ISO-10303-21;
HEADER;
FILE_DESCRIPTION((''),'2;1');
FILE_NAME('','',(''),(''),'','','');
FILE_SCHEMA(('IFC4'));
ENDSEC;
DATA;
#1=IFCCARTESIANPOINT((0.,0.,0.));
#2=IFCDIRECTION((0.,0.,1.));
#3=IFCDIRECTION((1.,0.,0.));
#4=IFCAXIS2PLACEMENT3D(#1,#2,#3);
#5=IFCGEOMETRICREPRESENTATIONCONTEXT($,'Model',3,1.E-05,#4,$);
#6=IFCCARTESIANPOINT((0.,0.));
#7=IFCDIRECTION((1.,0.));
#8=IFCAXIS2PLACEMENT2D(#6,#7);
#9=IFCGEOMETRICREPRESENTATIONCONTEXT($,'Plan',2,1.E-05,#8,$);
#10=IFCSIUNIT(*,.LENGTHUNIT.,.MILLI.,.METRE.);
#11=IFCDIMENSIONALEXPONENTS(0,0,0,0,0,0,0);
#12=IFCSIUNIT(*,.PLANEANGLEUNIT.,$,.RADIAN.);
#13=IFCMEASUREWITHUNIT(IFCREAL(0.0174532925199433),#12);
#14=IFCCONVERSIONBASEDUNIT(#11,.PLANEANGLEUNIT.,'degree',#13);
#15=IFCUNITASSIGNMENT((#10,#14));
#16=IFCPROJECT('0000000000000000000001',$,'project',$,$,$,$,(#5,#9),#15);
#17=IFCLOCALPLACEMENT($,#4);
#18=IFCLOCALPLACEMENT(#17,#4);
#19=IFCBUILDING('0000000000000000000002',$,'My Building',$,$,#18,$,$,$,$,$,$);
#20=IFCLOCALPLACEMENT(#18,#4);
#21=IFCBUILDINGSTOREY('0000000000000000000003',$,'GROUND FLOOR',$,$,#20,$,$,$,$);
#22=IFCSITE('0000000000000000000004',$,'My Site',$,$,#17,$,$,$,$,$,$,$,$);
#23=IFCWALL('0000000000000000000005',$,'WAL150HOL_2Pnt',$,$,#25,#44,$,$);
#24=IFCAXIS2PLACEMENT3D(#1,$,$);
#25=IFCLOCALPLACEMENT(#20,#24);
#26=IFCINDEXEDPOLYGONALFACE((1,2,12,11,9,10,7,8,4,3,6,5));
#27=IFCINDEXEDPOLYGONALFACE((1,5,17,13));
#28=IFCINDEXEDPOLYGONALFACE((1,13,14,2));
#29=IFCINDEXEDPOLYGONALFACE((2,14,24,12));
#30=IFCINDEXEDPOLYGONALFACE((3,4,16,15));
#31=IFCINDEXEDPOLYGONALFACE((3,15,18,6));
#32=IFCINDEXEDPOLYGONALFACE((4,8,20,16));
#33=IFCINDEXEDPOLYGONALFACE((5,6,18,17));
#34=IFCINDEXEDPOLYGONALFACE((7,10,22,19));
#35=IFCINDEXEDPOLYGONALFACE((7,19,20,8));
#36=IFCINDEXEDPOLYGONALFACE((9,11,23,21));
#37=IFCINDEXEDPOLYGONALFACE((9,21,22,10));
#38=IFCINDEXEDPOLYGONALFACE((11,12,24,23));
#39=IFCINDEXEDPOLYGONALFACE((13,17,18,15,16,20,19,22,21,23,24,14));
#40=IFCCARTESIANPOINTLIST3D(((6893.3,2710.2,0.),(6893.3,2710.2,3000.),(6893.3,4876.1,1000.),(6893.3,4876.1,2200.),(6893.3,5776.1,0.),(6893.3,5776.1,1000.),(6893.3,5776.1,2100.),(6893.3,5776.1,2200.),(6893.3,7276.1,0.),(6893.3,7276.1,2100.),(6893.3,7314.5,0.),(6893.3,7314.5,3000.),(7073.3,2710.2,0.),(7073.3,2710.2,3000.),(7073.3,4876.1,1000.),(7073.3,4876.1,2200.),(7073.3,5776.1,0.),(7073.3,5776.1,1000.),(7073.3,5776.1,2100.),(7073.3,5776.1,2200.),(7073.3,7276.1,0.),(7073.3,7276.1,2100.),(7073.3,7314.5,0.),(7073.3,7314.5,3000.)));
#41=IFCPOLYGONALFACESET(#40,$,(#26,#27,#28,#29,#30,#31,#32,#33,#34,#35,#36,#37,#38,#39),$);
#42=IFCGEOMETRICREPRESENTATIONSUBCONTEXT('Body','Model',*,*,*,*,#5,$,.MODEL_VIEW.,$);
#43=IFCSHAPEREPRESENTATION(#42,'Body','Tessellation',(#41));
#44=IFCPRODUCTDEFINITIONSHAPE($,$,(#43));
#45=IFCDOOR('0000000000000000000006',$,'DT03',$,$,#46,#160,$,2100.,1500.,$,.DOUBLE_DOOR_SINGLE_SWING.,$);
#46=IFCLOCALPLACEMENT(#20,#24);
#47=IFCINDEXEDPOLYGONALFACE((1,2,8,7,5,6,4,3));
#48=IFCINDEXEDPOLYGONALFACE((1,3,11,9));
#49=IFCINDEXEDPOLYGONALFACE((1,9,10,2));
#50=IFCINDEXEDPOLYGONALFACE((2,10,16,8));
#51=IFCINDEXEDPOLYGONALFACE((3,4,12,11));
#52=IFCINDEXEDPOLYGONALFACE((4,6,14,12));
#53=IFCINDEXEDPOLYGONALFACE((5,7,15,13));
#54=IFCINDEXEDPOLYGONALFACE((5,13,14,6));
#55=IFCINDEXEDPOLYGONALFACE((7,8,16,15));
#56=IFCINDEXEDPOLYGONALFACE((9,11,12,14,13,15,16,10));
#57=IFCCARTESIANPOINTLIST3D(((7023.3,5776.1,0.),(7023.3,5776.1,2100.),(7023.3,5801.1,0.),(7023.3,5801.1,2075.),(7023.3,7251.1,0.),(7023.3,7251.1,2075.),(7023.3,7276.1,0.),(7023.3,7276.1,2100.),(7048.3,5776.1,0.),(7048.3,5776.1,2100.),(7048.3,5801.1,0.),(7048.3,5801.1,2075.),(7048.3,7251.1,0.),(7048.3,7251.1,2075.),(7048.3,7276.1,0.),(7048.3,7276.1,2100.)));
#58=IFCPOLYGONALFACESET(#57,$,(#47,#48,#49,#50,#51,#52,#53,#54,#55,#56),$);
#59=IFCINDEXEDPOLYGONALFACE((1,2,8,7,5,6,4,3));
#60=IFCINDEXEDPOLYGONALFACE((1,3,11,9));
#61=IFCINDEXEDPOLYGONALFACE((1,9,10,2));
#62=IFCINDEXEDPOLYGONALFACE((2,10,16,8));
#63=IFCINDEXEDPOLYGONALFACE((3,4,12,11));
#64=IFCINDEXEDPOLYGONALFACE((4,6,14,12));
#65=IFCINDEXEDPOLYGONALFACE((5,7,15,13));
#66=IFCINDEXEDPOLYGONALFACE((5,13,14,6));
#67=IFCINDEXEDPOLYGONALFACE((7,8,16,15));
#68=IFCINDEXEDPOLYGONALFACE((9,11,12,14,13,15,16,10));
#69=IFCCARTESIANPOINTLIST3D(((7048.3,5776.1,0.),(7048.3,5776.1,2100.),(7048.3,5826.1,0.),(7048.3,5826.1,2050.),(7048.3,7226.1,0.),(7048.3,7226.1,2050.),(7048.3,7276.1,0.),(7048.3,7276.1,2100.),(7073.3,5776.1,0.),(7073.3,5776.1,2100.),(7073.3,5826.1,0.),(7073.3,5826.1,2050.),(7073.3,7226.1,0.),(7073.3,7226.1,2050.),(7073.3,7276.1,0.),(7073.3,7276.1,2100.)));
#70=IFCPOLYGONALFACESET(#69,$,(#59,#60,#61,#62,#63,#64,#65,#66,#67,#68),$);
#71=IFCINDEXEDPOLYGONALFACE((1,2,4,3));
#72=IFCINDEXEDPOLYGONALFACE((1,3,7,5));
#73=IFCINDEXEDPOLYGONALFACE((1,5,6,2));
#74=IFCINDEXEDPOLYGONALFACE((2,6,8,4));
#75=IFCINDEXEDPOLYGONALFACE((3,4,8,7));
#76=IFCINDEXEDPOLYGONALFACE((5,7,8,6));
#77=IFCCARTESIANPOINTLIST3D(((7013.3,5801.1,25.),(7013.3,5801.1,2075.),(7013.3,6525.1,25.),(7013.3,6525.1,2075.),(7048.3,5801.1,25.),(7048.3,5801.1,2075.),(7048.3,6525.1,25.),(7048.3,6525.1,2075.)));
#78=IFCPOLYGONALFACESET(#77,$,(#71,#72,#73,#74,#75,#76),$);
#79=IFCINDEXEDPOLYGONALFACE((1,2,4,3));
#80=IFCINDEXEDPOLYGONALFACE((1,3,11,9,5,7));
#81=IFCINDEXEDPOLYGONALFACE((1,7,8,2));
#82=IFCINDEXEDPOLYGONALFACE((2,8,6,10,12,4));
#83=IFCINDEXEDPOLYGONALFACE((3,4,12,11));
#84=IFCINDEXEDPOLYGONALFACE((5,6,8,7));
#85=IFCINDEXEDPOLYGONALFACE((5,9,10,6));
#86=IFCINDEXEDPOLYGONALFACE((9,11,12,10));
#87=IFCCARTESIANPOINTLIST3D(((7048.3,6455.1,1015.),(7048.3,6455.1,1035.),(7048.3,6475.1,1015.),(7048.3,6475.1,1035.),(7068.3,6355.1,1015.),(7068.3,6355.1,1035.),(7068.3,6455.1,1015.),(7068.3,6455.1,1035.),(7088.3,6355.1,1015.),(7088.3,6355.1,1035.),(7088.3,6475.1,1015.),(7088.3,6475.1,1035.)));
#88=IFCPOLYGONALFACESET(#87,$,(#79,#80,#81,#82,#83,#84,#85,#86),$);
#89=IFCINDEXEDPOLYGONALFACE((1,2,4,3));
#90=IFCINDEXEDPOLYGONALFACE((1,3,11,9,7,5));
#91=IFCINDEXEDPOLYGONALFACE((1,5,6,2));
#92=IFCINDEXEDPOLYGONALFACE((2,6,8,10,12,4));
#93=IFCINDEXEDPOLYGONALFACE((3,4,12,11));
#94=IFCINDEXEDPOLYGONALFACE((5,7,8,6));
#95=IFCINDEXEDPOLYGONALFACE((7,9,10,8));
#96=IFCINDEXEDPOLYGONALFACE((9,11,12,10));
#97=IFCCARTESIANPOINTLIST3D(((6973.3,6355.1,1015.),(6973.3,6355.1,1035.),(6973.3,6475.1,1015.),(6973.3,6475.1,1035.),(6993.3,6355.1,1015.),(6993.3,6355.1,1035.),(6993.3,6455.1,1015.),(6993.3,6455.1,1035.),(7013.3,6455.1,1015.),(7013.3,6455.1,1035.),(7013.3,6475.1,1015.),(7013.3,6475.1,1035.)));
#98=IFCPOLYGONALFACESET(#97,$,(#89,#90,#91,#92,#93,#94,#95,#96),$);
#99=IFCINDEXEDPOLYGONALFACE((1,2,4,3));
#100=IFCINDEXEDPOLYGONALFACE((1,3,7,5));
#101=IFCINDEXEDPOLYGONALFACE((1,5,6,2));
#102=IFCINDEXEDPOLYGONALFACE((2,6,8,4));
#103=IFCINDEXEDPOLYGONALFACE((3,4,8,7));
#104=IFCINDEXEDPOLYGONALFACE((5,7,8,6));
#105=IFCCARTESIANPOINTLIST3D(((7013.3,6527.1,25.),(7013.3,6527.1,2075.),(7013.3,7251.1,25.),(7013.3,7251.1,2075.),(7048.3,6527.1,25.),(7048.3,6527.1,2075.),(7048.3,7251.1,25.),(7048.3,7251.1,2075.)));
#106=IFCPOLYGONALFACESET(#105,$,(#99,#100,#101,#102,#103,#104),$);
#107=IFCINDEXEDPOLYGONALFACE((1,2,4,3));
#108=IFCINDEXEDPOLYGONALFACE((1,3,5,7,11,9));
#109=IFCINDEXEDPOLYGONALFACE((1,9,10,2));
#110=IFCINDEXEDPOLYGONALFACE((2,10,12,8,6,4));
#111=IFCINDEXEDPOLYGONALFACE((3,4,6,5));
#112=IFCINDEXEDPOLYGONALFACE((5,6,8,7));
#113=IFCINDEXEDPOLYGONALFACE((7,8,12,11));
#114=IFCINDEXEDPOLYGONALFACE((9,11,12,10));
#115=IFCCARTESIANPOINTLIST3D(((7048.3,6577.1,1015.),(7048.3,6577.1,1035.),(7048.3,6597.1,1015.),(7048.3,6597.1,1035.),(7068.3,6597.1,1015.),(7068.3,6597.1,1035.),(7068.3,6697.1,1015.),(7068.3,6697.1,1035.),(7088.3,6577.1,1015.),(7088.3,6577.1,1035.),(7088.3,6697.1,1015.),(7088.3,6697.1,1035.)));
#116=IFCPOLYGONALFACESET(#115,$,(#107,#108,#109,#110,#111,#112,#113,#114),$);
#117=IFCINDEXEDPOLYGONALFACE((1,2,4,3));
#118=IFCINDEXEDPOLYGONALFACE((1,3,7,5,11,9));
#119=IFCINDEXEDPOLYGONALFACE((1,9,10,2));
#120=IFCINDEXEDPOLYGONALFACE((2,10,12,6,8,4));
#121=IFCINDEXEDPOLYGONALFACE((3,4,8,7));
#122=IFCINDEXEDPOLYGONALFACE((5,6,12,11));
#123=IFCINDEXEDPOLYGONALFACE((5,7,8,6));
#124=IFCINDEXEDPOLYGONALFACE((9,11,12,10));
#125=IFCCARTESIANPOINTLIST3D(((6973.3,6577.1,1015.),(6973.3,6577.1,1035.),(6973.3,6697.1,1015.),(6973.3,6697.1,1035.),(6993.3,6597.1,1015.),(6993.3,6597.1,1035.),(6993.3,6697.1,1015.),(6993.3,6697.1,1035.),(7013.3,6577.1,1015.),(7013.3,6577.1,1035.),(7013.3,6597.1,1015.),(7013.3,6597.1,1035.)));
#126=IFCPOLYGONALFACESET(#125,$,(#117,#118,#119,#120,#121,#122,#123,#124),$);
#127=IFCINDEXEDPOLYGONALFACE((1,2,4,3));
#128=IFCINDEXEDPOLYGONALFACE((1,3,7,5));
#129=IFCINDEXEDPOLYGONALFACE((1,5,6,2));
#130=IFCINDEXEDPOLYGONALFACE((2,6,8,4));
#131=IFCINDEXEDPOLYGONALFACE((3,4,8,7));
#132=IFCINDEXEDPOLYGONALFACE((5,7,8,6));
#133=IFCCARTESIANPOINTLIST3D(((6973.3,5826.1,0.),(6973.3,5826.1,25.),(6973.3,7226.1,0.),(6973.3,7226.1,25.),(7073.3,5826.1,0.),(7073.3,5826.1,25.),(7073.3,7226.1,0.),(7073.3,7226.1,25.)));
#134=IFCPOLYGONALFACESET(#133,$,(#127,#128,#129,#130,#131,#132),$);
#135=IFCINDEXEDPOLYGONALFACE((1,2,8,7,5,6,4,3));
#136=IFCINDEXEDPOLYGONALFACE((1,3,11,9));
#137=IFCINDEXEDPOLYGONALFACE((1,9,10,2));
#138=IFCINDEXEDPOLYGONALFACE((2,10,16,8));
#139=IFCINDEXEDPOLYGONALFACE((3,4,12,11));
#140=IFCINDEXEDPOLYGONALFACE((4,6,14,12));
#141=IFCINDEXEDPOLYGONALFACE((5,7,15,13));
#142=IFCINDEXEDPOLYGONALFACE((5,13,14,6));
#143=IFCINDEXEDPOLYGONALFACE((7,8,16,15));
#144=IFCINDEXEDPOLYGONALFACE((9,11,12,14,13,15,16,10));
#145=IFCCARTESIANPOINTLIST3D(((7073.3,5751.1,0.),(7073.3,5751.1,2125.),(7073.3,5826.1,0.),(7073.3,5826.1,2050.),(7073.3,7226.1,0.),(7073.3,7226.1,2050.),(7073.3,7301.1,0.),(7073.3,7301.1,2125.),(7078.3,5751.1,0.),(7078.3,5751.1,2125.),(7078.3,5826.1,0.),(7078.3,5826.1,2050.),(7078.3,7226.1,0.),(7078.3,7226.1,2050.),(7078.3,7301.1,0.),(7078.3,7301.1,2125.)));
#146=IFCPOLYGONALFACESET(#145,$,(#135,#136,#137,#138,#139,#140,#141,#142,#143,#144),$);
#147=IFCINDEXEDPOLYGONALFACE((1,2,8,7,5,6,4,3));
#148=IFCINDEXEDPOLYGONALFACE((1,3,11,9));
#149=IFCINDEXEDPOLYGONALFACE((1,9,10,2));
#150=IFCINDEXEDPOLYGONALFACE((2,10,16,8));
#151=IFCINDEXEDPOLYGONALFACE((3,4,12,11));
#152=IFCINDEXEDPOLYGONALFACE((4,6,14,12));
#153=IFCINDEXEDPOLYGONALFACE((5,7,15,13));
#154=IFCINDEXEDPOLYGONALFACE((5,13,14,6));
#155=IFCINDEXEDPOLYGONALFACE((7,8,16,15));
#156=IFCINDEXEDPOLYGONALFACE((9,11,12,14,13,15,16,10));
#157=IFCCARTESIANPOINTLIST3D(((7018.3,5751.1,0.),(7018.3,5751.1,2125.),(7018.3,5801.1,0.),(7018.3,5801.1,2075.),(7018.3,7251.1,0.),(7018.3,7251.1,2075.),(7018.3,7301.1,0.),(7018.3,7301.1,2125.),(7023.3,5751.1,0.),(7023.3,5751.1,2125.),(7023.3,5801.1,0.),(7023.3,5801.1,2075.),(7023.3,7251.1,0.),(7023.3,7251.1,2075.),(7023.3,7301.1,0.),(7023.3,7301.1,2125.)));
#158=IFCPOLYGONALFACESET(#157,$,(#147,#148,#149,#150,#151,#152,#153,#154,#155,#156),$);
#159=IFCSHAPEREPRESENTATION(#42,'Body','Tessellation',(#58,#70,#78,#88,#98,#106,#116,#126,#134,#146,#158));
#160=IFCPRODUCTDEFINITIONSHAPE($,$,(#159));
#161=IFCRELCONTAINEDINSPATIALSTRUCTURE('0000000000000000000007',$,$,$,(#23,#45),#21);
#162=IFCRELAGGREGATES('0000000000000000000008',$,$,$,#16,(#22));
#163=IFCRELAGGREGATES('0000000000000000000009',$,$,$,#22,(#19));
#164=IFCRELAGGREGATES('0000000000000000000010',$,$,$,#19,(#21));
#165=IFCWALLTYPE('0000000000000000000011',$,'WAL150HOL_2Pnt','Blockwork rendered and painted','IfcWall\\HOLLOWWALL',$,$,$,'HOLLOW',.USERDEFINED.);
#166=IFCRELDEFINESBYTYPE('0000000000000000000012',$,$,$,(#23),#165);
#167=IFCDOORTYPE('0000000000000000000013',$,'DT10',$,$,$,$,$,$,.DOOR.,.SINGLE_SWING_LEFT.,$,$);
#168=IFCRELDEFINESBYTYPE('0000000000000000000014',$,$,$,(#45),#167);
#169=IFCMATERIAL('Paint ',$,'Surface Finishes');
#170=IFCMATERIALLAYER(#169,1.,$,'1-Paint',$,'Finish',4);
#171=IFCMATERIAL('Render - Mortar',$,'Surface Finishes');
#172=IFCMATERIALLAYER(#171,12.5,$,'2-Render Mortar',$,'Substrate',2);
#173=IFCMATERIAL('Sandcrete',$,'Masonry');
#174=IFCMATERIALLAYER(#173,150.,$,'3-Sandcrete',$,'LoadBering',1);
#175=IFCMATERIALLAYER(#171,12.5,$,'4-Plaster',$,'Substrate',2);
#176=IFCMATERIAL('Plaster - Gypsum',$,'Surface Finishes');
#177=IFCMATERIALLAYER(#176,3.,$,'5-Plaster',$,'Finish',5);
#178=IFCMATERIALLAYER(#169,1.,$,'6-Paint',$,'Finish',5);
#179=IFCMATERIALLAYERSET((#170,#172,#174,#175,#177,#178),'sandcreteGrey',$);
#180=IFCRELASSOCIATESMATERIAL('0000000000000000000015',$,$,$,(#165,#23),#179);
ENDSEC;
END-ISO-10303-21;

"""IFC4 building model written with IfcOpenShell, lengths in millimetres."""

from ifc_helpers import new_model, entity, si_unit, converted_unit, frame, origin_with_axes, origin_2d_with_axis, place, context, subcontext, project, spatial, line, indexed_curve, outline, extrude, shape, source, transform, mapped, material, layer, layer_set, layer_usage, type_object, type_shapes, element, fill, save


model = new_model("IFC4")

# Units and contexts
model_context = context("Model", 3, precision=1e-05, world=origin_with_axes())
plan_context = context("Plan", 2, precision=1e-05, world=origin_2d_with_axis())
body_context_1 = subcontext(model_context, "Body", "Model", "MODEL_VIEW")
body_context_2 = subcontext(plan_context, "Body", "Plan", "PLAN_VIEW")
ifc_project = project(units=[si_unit("LENGTHUNIT", "METRE", prefix="MILLI"), converted_unit("PLANEANGLEUNIT", "degree", entity("IfcReal", 0.0174532925199433), si_unit("PLANEANGLEUNIT", "RADIAN"), dimensions=[0, 0, 0, 0, 0, 0, 0])], contexts=[model_context, plan_context])

# Site, building, storey
site_placement = place(None, origin_with_axes())
site = spatial("IfcSite", under=ifc_project, at=site_placement, Name="My Site")
building_placement = place(site_placement, origin_with_axes())
building = spatial("IfcBuilding", under=site, at=building_placement, Name="My Building")
storey_placement = place(building_placement, origin_with_axes())
storey = spatial("IfcBuildingStorey", under=building, at=storey_placement, Name="GROUND FLOOR")

# Shared definitions
ifc_material_1 = material(Name="Paint ", Category="Surface Finishes")
ifc_layer_1 = layer(ifc_material_1, 1.0, Name="1-Paint", Category="Finish", Priority=4)
ifc_material_2 = material(Name="Render - Mortar", Category="Surface Finishes")
ifc_layer_2 = layer(ifc_material_2, 12.5, Name="2-Render Mortar", Category="Substrate", Priority=2)
ifc_material_3 = material(Name="Sandcrete", Category="Masonry")
ifc_layer_3 = layer(ifc_material_3, 150.0, Name="3-Sandcrete", Category="LoadBering", Priority=1)
ifc_layer_4 = layer(ifc_material_2, 12.5, Name="4-Plaster", Category="Substrate", Priority=2)
ifc_material_4 = material(Name="Plaster - Gypsum", Category="Surface Finishes")
ifc_layer_5 = layer(ifc_material_4, 3.0, Name="5-Plaster", Category="Finish", Priority=5)
ifc_layer_6 = layer(ifc_material_1, 1.0, Name="6-Paint", Category="Finish", Priority=5)
ifc_layer_set_1 = layer_set([ifc_layer_1, ifc_layer_2, ifc_layer_3, ifc_layer_4, ifc_layer_5, ifc_layer_6], Name="sandcreteGrey")
wall_type_1 = type_object("IfcWallType", Name="WAL150HOL_2Pnt", Description="Blockwork rendered and painted", ApplicableOccurrence="IfcWall\\HOLLOWWALL", ElementType="HOLLOW", PredefinedType="USERDEFINED", material=ifc_layer_set_1)

# Wall, openings, door
ifc_layer_usage_1 = layer_usage(ifc_layer_set_1, "AXIS2", "POSITIVE", 0.0)
wall_1_placement = place(storey_placement, frame((7073.3, 2710.2, 0.0), z_axis=(0.0, 0.0, 1.0), x_axis=(0.000002, 1.0, 0.0)))
wall_1 = element("IfcWall", 1, at=wall_1_placement, inside=storey, type_object=wall_type_1, material=ifc_layer_usage_1, Name="WAL150HOL_2Pnt", context=body_context_1, shape_type="SweptSolid", body=[
    extrude(outline(indexed_curve([(0.0, 0.0), (0.0, 180.0), (4604.3, 180.0), (4604.3, 0.0), (0.0, 0.0)], self_intersect=False)), origin_with_axes(), (0.0, 0.0, 1.0), 3000.0),
])
shared_shape_1 = source(origin_with_axes(), body_context_1, "Body", "SweptSolid", [
    extrude(outline(indexed_curve([(0.0, 0.0), (1500.0, 0.0), (1500.0, 2100.0), (0.0, 2100.0)], segments=[line(1, 2, 3, 4, 1)])), frame((0.0, -100.0, 0.0), z_axis=(0.0, -1.0, 0.0), x_axis=(1.0, 0.0, 0.0)), (0.0, 0.0, -1.0), 380.0),
])
opening_1_placement = place(wall_1_placement, frame((3066.0, 0.0, 0.0), z_axis=(0.0, 0.0, 1.0), x_axis=(1.0, 0.0, 0.0)))
opening_1 = element("IfcOpeningElement", 2, at=opening_1_placement, cuts=wall_1, PredefinedType="OPENING", context=body_context_1, shape_type="MappedRepresentation", body=[
    mapped(shared_shape_1, transform((0.0, 0.0, 0.0), x_axis=(1.0, 0.0, 0.0), y_axis=(0.0, 1.0, 0.0), z_axis=(0.0, 0.0, 1.0), scale=1.0)),
])
shared_shape_2 = source(origin_with_axes(), body_context_1, "Body", "SweptSolid", [
    extrude(outline(indexed_curve([(0.0, 0.0), (900.0, 0.0), (900.0, 1200.0), (0.0, 1200.0)], segments=[line(1, 2, 3, 4, 1)])), frame((0.0, -600.0, 0.0), z_axis=(0.0, -1.0, 0.0), x_axis=(1.0, 0.0, 0.0)), (0.0, 0.0, -1.0), 1200.0),
])
opening_2_placement = place(wall_1_placement, frame((2166.0, 0.0, 1000.0), z_axis=(0.0, 0.0, 1.0), x_axis=(1.0, 0.0, 0.0)))
element("IfcOpeningElement", 3, at=opening_2_placement, cuts=wall_1, PredefinedType="OPENING", context=body_context_1, shape_type="MappedRepresentation", body=[
    mapped(shared_shape_2, transform((0.0, 0.0, 0.0), x_axis=(1.0, 0.0, 0.0), y_axis=(0.0, 1.0, 0.0), z_axis=(0.0, 0.0, 1.0), scale=1.0)),
])
door_type_1 = type_object("IfcDoorType", Name="DT10", OperationType="SINGLE_SWING_LEFT", PredefinedType="DOOR")
shared_shape_3 = source(origin_with_axes(), body_context_1, "Body", "SweptSolid", [
    extrude(outline(indexed_curve([(0.0, 0.0), (0.0, 2100.0), (1500.0, 2100.0), (1500.0, 0.0), (1475.0, 0.0), (1475.0, 2075.0), (25.0, 2075.0), (25.0, 0.0)], segments=[line(1, 2, 3, 4, 5, 6, 7, 8, 1)])), frame((0.0, 25.0, 0.0), z_axis=(0.0, -1.0, 0.0), x_axis=(1.0, 0.0, 0.0)), (0.0, 0.0, -1.0), 25.0),
    extrude(outline(indexed_curve([(0.0, 0.0), (0.0, 2100.0), (1500.0, 2100.0), (1500.0, 0.0), (1450.0, 0.0), (1450.0, 2050.0), (50.0, 2050.0), (50.0, 0.0)], segments=[line(1, 2, 3, 4, 5, 6, 7, 8, 1)])), frame((0.0, 0.0, 0.0), z_axis=(0.0, -1.0, 0.0), x_axis=(1.0, 0.0, 0.0)), (0.0, 0.0, -1.0), 25.0),
    extrude(outline(indexed_curve([(0.0, 0.0), (724.0, 0.0), (724.0, 35.0), (0.0, 35.0)], segments=[line(1, 2, 3, 4, 1)])), frame((25.0, 25.0, 25.0), z_axis=(0.0, 0.0, 1.0), x_axis=(1.0, 0.0, 0.0)), (0.0, 0.0, 1.0), 2050.0),
    extrude(outline(indexed_curve([(0.0, 0.0), (0.0, -40.0), (-120.0, -40.0), (-120.0, -20.0), (-20.0, -20.0), (-20.0, 0.0)], segments=[line(1, 2, 3, 4, 5, 6, 1)])), frame((699.0, 25.0, 1015.0), z_axis=(0.0, 0.0, 1.0), x_axis=(1.0, 0.0, 0.0)), (0.0, 0.0, 1.0), 20.0),
    extrude(outline(indexed_curve([(0.0, 0.0), (0.0, 40.0), (-120.0, 40.0), (-120.0, 20.0), (-20.0, 20.0), (-20.0, 0.0)], segments=[line(1, 2, 3, 4, 5, 6, 1)])), frame((699.0, 60.0, 1015.0), z_axis=(0.0, 0.0, 1.0), x_axis=(1.0, 0.0, 0.0)), (0.0, 0.0, 1.0), 20.0),
    extrude(outline(indexed_curve([(0.0, 0.0), (-724.0, 0.0), (-724.0, 35.0), (0.0, 35.0)], segments=[line(1, 2, 3, 4, 1)])), frame((1475.0, 25.0, 25.0), z_axis=(0.0, 0.0, 1.0), x_axis=(1.0, 0.0, 0.0)), (0.0, 0.0, 1.0), 2050.0),
    extrude(outline(indexed_curve([(0.0, 0.0), (0.0, -40.0), (120.0, -40.0), (120.0, -20.0), (20.0, -20.0), (20.0, 0.0)], segments=[line(1, 2, 3, 4, 5, 6, 1)])), frame((801.0, 25.0, 1015.0), z_axis=(0.0, 0.0, 1.0), x_axis=(1.0, 0.0, 0.0)), (0.0, 0.0, 1.0), 20.0),
    extrude(outline(indexed_curve([(0.0, 0.0), (0.0, 40.0), (120.0, 40.0), (120.0, 20.0), (20.0, 20.0), (20.0, 0.0)], segments=[line(1, 2, 3, 4, 5, 6, 1)])), frame((801.0, 60.0, 1015.0), z_axis=(0.0, 0.0, 1.0), x_axis=(1.0, 0.0, 0.0)), (0.0, 0.0, 1.0), 20.0),
    extrude(outline(indexed_curve([(0.0, 0.0), (1400.0, 0.0), (1400.0, 100.0), (0.0, 100.0)], segments=[line(1, 2, 3, 4, 1)])), frame((50.0, 0.0, 0.0), z_axis=(0.0, 0.0, 1.0), x_axis=(1.0, 0.0, 0.0)), (0.0, 0.0, 1.0), 25.0),
    extrude(outline(indexed_curve([(0.0, 0.0), (0.0, 2125.0), (1550.0, 2125.0), (1550.0, 0.0), (1475.0, 0.0), (1475.0, 2050.0), (75.0, 2050.0), (75.0, 0.0)], segments=[line(1, 2, 3, 4, 5, 6, 7, 8, 1)])), frame((-25.0, -5.0, 0.0), z_axis=(0.0, -1.0, 0.0), x_axis=(1.0, 0.0, 0.0)), (0.0, 0.0, -1.0), 5.0),
    extrude(outline(indexed_curve([(0.0, 0.0), (0.0, 2125.0), (1550.0, 2125.0), (1550.0, 0.0), (1500.0, 0.0), (1500.0, 2075.0), (50.0, 2075.0), (50.0, 0.0)], segments=[line(1, 2, 3, 4, 5, 6, 7, 8, 1)])), frame((-25.0, 50.0, 0.0), z_axis=(0.0, -1.0, 0.0), x_axis=(1.0, 0.0, 0.0)), (0.0, 0.0, -1.0), 5.0),
])
shared_shape_4 = source(origin_with_axes(), body_context_2, "Body", "Curve2D", [
    entity("IfcIndexedPolyCurve", entity("IfcCartesianPointList2D", [[0.0, 0.0], [0.0, 50.0], [25.0, 50.0], [25.0, 25.0], [50.0, 25.0], [50.0, 0.0]]), [entity("IfcLineIndex", [1, 2, 3, 4, 5, 6, 1])]),
    entity("IfcIndexedPolyCurve", entity("IfcCartesianPointList2D", [[1500.0, 0.0], [1500.0, 50.0], [1475.0, 50.0], [1475.0, 25.0], [1450.0, 25.0], [1450.0, 0.0]]), [entity("IfcLineIndex", [1, 2, 3, 4, 5, 6, 1])]),
    entity("IfcTrimmedCurve", entity("IfcEllipse", entity("IfcAxis2Placement2D", entity("IfcCartesianPoint", [60.0, 50.0]), entity("IfcDirection", [1.0, 0.0])), 690.0, 725.0), [entity("IfcCartesianPoint", [750.0, 50.0])], [entity("IfcCartesianPoint", [60.0, 775.0])], True, "CARTESIAN"),
    entity("IfcIndexedPolyCurve", entity("IfcCartesianPointList2D", [[25.0, 50.0], [60.0, 50.0], [60.0, 775.0], [25.0, 775.0]]), [entity("IfcLineIndex", [1, 2, 3, 4, 1])]),
    entity("IfcTrimmedCurve", entity("IfcEllipse", entity("IfcAxis2Placement2D", entity("IfcCartesianPoint", [1440.0, 50.0]), entity("IfcDirection", [1.0, 0.0])), 690.0, 725.0), [entity("IfcCartesianPoint", [1440.0, 775.0])], [entity("IfcCartesianPoint", [750.0, 50.0])], True, "CARTESIAN"),
    entity("IfcIndexedPolyCurve", entity("IfcCartesianPointList2D", [[1475.0, 50.0], [1440.0, 50.0], [1440.0, 775.0], [1475.0, 775.0]]), [entity("IfcLineIndex", [1, 2, 3, 4, 1])]),
])
type_shapes(door_type_1, [shared_shape_3, shared_shape_4])
door_1_placement = place(opening_1_placement, frame((0.0, 0.0, 0.0), z_axis=(0.0, 0.0, 1.0), x_axis=(1.0, 0.0, 0.0)))
door_1 = element("IfcDoor", 4, at=door_1_placement, inside=storey, type_object=door_type_1, Name="DT03", OperationType="DOUBLE_DOOR_SINGLE_SWING", OverallHeight=2100.0, OverallWidth=1500.0, shapes=[
    shape(body_context_1, "Body", "MappedRepresentation", [mapped(shared_shape_3, transform((0.0, 0.0, 0.0), x_axis=(1.0, 0.0, 0.0), y_axis=(0.0, 1.0, 0.0), z_axis=(0.0, 0.0, 1.0), scale=1.0))]),
    shape(body_context_2, "Body", "MappedRepresentation", [mapped(shared_shape_4, transform((0.0, 0.0, 0.0), x_axis=(1.0, 0.0, 0.0), y_axis=(0.0, 1.0, 0.0), z_axis=(0.0, 0.0, 1.0), scale=1.0))]),
])
fill(opening_1, door_1)

save(model, "model.ifc")
